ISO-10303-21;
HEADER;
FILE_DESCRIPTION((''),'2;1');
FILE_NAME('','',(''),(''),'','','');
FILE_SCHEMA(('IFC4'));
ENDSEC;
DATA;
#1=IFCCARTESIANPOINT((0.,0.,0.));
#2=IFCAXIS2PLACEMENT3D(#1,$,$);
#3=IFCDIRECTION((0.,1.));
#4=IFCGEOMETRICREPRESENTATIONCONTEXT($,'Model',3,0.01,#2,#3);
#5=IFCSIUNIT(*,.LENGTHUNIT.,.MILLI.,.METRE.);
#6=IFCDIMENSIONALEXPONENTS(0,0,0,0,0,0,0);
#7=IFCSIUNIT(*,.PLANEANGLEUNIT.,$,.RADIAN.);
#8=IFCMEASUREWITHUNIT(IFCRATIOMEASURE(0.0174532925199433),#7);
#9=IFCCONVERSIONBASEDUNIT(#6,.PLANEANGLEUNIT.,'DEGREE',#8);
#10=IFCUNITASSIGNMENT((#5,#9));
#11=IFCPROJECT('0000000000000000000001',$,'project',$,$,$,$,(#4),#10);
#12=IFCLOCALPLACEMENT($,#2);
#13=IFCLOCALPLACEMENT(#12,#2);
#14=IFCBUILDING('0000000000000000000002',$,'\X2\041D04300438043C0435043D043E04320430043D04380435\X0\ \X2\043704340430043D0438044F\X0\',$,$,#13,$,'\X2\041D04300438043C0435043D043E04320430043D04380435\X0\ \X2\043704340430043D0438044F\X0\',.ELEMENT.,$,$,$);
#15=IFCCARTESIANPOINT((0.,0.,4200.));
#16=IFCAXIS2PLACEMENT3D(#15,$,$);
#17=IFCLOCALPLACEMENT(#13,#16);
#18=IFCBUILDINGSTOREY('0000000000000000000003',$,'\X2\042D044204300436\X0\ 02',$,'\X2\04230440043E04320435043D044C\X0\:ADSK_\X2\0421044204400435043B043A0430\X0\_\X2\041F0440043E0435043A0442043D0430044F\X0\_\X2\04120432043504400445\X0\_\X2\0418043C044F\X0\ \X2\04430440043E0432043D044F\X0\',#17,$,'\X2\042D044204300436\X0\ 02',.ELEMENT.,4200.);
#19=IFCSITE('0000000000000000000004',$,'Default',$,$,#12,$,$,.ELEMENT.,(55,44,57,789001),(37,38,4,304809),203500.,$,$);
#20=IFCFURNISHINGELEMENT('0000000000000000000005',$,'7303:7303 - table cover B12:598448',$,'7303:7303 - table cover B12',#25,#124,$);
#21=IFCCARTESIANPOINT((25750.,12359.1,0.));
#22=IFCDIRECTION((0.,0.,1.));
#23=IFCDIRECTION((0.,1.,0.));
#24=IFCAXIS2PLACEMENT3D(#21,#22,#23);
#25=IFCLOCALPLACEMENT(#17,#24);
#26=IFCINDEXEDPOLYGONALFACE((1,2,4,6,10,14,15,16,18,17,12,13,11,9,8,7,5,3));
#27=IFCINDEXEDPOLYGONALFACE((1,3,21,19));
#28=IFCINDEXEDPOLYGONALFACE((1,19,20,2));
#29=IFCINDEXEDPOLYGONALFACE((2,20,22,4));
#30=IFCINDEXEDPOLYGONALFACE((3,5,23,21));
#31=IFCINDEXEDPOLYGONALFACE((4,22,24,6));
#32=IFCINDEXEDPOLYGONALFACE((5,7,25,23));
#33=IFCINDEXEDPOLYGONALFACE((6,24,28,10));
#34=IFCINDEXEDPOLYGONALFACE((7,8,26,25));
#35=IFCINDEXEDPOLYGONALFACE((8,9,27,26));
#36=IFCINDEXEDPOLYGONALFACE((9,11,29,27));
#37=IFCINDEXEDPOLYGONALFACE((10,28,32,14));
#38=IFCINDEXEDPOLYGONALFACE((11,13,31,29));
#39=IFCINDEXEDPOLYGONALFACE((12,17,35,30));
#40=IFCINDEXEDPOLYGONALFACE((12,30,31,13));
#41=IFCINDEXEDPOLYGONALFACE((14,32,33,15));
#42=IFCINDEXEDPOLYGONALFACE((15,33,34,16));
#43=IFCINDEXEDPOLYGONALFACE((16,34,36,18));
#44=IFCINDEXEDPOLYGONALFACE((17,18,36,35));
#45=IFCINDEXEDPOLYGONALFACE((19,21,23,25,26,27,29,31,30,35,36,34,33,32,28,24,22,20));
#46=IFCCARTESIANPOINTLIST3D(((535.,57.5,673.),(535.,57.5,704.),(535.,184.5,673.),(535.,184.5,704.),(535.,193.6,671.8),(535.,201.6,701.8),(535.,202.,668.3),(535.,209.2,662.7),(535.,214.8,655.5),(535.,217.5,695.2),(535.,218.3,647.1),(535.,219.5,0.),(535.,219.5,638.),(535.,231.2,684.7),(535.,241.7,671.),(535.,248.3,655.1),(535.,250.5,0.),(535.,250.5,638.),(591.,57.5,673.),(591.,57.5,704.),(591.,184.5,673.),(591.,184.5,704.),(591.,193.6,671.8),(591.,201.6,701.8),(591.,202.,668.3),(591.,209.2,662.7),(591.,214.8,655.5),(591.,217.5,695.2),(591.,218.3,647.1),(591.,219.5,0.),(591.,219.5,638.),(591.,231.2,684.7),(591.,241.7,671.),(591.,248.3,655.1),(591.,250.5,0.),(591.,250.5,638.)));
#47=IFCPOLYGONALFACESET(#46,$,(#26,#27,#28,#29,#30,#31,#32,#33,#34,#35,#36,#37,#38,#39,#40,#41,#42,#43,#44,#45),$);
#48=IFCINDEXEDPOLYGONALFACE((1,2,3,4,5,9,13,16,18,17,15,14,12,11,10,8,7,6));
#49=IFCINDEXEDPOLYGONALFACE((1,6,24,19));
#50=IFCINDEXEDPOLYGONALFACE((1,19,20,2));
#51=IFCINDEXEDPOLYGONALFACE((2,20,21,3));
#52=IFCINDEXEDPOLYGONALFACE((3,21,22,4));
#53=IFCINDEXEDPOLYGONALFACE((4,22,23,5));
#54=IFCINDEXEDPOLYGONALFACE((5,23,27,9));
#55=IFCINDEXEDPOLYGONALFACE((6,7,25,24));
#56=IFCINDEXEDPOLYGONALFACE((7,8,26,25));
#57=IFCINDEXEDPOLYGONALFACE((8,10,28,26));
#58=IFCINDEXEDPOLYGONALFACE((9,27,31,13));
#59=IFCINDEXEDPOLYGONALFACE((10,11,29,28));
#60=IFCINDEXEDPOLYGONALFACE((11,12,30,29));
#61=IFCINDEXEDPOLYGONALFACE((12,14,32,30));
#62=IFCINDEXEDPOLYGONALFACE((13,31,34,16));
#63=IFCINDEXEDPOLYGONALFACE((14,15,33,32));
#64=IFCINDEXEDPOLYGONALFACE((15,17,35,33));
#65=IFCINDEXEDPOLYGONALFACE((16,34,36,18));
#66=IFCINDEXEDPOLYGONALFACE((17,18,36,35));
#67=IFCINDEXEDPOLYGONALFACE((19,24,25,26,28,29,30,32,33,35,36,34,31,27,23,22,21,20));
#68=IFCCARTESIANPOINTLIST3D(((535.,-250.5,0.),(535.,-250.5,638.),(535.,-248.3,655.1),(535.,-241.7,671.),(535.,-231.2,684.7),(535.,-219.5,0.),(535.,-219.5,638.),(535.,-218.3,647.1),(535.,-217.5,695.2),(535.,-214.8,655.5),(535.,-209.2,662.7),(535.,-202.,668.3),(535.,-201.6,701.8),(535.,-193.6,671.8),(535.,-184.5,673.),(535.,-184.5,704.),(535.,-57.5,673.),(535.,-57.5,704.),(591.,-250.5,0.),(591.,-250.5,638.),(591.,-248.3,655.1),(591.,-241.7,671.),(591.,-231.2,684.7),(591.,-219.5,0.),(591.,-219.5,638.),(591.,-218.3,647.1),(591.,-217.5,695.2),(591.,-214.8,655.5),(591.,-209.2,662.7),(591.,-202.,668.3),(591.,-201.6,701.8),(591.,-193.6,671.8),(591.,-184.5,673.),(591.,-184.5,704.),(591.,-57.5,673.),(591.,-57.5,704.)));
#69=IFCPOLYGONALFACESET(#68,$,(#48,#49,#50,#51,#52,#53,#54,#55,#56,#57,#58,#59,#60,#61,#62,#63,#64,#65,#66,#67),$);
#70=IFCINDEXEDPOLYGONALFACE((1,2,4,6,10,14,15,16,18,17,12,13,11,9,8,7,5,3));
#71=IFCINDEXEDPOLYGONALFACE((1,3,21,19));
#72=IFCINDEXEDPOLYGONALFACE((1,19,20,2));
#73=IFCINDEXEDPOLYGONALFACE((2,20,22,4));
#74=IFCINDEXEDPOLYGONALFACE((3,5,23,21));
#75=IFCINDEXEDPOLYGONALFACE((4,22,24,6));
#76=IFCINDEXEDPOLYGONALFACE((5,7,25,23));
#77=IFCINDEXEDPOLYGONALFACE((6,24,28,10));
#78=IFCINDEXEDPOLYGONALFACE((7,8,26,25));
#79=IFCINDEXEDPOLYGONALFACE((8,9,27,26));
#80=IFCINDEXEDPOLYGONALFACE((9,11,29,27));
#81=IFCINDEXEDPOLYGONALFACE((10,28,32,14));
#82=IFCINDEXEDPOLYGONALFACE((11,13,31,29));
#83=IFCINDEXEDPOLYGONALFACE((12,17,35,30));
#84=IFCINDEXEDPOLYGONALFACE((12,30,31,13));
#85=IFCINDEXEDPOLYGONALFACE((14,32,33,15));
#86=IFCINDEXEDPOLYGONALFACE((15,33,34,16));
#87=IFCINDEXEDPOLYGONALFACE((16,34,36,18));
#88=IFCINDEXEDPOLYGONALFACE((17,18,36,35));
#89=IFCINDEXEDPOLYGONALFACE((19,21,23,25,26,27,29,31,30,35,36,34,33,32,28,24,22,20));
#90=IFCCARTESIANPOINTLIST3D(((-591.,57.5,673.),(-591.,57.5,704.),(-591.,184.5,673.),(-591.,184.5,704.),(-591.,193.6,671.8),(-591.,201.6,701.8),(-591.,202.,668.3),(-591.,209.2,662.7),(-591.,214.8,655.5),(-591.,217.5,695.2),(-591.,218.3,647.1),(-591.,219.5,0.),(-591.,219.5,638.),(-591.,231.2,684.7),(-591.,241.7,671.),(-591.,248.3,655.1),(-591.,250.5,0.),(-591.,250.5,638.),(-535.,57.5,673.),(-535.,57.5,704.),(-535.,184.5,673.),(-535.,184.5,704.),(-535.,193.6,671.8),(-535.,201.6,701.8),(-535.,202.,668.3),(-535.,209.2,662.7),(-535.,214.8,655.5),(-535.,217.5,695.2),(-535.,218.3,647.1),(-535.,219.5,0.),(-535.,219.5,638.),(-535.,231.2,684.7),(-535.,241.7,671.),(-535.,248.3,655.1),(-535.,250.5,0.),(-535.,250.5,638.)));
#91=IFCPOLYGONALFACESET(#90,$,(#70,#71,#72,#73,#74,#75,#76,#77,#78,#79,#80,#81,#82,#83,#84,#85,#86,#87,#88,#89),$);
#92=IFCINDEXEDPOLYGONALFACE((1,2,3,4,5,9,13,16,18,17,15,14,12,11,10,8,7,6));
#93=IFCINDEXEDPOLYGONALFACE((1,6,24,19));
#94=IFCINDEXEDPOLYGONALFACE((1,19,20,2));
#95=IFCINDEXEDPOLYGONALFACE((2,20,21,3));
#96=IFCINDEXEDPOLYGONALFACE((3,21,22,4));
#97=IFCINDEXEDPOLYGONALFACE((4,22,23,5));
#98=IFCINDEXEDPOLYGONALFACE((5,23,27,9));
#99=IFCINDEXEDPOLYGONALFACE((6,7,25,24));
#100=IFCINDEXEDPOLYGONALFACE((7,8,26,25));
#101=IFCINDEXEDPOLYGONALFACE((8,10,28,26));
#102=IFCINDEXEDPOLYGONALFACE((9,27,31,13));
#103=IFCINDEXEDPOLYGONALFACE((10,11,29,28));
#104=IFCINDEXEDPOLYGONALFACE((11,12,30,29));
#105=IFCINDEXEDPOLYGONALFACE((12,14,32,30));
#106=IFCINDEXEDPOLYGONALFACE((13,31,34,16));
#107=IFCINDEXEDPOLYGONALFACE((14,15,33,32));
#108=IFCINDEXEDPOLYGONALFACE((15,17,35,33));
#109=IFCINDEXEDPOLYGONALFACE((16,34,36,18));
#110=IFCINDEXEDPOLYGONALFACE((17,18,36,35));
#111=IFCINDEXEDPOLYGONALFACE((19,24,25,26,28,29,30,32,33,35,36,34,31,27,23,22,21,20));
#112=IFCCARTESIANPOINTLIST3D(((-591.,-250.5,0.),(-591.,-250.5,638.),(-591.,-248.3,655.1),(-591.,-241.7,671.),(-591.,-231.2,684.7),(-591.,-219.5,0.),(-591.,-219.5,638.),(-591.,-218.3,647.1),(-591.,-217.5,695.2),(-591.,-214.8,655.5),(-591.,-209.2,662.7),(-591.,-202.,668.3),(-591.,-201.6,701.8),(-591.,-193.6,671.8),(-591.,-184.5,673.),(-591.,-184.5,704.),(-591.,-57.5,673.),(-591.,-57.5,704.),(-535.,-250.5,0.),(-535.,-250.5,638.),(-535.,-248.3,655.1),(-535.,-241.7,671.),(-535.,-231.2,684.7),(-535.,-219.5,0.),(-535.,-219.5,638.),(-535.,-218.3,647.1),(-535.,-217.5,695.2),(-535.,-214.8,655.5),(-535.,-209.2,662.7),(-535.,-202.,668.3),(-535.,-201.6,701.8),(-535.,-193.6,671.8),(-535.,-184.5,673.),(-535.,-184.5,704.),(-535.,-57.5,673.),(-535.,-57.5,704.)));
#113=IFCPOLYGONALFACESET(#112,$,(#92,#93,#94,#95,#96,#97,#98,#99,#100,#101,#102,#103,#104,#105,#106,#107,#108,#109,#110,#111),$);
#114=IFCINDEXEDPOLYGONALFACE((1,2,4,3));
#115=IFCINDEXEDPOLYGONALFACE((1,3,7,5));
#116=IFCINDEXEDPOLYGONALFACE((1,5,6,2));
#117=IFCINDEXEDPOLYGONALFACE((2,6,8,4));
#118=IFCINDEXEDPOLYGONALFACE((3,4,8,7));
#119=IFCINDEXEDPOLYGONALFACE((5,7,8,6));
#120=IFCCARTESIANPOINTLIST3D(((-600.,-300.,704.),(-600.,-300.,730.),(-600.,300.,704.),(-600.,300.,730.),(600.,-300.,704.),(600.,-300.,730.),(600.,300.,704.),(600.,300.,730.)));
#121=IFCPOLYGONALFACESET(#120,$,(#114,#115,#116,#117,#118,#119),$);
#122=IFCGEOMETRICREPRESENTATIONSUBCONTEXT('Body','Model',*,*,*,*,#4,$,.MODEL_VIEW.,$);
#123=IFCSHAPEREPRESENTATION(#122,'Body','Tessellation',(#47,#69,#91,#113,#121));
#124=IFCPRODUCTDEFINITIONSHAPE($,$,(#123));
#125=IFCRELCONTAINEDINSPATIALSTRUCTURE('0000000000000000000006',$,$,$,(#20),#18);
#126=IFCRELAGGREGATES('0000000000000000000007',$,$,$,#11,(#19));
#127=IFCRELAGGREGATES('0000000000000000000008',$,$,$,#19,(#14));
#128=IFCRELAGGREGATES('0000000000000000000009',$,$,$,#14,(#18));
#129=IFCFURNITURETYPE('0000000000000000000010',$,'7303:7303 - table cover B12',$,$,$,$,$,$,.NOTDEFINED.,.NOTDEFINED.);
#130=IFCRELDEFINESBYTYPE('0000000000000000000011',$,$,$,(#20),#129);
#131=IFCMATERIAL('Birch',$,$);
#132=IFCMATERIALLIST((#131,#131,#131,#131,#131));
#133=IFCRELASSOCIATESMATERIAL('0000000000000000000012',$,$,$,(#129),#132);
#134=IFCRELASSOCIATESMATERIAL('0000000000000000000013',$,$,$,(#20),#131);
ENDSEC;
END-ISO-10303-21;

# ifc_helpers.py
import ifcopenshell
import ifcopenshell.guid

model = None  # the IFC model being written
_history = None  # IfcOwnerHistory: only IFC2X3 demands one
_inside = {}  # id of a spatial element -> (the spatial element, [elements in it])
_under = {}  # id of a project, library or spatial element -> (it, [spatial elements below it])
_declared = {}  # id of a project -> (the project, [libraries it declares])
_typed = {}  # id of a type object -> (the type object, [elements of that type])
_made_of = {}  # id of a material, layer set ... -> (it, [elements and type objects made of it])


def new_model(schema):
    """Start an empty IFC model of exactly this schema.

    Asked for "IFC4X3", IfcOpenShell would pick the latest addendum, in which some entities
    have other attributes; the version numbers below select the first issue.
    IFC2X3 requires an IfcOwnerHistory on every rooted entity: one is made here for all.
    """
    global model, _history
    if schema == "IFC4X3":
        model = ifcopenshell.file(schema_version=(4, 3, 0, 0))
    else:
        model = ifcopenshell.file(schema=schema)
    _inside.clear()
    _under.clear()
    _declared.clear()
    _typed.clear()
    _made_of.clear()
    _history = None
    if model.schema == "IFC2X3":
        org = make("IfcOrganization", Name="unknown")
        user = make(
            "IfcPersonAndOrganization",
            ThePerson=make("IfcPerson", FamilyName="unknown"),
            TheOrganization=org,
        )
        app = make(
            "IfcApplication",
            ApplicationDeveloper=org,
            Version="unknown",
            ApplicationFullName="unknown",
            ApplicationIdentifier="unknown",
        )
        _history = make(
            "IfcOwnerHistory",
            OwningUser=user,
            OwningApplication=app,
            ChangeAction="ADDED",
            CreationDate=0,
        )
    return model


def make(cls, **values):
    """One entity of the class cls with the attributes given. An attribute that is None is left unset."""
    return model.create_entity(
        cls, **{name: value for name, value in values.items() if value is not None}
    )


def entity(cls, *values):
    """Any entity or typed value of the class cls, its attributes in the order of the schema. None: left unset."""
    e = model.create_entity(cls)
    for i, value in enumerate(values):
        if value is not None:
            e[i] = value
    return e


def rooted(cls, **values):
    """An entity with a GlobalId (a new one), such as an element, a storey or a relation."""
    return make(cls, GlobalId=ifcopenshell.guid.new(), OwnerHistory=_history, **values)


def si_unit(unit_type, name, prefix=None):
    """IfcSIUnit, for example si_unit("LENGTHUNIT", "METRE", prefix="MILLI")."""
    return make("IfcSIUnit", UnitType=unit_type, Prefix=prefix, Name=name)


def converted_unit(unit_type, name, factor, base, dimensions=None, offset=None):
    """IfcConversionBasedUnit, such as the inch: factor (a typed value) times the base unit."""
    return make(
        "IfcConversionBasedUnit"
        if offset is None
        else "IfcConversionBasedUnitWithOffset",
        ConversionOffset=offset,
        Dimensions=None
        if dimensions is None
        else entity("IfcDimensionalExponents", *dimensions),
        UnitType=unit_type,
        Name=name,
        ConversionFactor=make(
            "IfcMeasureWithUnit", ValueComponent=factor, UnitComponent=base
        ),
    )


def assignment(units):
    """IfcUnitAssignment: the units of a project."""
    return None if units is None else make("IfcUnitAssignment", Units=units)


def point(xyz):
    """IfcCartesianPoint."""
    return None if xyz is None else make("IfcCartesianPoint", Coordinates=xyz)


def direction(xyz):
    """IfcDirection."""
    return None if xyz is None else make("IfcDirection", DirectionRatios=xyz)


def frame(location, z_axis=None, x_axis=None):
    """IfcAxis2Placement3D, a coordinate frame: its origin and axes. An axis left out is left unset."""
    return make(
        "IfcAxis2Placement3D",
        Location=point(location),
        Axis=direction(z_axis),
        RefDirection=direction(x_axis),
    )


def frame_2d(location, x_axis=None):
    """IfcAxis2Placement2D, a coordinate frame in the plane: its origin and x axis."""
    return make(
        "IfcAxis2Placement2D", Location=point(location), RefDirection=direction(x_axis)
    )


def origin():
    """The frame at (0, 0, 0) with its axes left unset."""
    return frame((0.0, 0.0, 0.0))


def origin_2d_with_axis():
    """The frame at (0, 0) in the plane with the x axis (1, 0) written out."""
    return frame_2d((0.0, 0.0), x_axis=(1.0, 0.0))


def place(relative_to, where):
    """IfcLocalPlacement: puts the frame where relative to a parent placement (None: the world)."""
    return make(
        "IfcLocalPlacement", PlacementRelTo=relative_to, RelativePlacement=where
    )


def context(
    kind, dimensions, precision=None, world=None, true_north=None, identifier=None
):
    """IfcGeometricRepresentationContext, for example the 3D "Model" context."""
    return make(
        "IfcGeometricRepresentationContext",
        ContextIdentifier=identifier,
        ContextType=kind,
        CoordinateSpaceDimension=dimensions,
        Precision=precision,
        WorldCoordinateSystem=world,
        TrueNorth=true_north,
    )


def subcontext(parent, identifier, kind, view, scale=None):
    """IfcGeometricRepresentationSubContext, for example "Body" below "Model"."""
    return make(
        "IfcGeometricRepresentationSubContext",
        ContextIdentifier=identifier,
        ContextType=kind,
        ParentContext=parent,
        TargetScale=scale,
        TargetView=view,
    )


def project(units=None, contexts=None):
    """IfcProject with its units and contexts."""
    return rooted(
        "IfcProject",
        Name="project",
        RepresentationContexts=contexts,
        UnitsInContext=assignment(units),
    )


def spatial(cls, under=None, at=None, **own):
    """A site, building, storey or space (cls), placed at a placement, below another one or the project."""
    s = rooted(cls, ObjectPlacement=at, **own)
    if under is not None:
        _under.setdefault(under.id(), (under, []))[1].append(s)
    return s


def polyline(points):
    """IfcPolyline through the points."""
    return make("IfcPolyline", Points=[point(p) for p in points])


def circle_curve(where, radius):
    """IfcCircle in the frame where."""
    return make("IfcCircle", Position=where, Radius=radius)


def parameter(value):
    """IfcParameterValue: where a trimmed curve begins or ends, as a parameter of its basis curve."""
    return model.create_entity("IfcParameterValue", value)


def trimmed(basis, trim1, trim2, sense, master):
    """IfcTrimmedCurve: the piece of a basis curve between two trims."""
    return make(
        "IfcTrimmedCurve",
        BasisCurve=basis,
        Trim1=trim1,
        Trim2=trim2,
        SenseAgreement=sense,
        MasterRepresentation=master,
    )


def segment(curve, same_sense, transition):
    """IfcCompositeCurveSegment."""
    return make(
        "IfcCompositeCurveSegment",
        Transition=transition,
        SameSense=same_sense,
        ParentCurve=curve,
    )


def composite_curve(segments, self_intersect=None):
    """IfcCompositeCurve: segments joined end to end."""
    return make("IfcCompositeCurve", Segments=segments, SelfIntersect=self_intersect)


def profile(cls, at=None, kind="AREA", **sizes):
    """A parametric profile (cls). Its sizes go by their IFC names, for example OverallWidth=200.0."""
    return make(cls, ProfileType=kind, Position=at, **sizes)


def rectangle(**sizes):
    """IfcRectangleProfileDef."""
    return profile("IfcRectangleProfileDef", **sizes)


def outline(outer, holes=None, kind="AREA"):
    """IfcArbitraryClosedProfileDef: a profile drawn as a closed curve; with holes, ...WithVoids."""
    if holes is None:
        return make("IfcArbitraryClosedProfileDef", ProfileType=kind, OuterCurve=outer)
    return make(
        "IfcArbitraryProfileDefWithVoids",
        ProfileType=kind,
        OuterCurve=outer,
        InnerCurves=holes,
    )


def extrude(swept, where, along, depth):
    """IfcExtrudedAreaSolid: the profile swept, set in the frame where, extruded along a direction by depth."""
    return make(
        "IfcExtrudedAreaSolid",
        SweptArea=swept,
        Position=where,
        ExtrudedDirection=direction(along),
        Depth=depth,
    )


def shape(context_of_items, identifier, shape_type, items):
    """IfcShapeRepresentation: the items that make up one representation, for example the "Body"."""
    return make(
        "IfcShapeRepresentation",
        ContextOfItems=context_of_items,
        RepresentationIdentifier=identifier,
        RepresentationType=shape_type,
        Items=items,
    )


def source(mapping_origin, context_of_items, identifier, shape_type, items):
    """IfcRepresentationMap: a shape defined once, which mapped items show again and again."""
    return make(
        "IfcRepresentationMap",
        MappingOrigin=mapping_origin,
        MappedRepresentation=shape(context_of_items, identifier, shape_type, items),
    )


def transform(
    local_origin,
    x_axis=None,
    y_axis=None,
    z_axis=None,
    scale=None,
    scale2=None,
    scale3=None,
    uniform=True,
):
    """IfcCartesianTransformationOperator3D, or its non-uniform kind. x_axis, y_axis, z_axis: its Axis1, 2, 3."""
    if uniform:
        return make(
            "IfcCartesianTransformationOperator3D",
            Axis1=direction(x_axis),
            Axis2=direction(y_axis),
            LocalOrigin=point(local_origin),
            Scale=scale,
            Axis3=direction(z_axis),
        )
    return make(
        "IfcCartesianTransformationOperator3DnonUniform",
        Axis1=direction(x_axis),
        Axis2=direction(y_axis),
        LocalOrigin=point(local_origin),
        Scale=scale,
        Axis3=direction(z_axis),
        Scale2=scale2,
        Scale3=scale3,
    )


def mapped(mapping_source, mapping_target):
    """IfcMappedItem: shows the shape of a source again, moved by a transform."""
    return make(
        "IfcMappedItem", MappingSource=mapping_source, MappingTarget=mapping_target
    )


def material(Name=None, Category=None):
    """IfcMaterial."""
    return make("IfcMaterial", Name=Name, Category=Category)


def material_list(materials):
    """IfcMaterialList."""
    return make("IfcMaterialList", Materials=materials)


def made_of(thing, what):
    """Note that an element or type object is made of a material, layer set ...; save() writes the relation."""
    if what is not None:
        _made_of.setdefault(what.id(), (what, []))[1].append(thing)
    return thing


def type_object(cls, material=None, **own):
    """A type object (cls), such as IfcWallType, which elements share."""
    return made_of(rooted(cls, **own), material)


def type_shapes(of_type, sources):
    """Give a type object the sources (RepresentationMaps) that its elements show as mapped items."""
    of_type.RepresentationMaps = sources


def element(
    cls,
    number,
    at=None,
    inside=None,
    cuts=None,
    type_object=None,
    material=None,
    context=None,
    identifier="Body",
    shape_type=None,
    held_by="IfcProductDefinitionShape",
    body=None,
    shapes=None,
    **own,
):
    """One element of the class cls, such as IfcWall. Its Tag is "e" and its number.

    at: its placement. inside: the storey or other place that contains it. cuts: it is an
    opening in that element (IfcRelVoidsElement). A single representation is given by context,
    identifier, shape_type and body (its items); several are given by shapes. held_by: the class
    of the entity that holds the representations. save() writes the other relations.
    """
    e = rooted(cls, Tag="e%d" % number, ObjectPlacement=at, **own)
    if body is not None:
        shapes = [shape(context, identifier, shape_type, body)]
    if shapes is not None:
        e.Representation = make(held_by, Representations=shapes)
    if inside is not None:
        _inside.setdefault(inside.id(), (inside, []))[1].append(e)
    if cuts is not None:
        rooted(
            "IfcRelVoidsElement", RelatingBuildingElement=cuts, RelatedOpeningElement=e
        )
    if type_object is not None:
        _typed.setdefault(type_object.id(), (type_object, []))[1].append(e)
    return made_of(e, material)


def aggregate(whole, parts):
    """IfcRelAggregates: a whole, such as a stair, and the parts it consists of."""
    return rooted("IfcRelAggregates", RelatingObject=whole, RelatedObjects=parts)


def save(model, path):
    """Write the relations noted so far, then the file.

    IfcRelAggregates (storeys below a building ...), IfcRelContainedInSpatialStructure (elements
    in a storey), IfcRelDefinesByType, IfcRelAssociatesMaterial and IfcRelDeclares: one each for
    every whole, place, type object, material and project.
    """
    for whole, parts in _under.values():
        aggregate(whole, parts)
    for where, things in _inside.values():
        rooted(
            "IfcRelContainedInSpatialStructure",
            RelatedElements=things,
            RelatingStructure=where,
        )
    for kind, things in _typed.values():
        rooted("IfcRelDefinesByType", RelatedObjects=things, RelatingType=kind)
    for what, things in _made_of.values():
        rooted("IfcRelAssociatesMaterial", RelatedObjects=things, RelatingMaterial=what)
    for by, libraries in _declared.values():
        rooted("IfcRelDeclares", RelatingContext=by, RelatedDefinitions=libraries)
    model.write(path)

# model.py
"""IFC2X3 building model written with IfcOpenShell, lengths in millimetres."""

from ifc_helpers import new_model, entity, si_unit, converted_unit, direction, frame, frame_2d, origin, origin_2d_with_axis, place, context, subcontext, project, spatial, polyline, circle_curve, parameter, trimmed, segment, composite_curve, rectangle, outline, extrude, source, transform, mapped, material, material_list, type_object, type_shapes, element, save


model = new_model("IFC2X3")

# Units and contexts
model_context = context("Model", 3, precision=0.01, world=origin(), true_north=direction((0.0, 1.0)))
body_context = subcontext(model_context, "Body", "Model", "MODEL_VIEW")
ifc_project = project(units=[si_unit("LENGTHUNIT", "METRE", prefix="MILLI"), converted_unit("PLANEANGLEUNIT", "DEGREE", entity("IfcRatioMeasure", 0.0174532925199433), si_unit("PLANEANGLEUNIT", "RADIAN"), dimensions=[0, 0, 0, 0, 0, 0, 0])], contexts=[model_context])

# Site, building, storey
site_placement = place(None, origin())
site = spatial("IfcSite", under=ifc_project, at=site_placement, Name="Default", CompositionType="ELEMENT", RefLatitude=(55, 44, 57, 789001), RefLongitude=(37, 38, 4, 304809), RefElevation=203500.0)
building_placement = place(site_placement, origin())
building = spatial("IfcBuilding", under=site, at=building_placement, Name="Наименование здания", LongName="Наименование здания", CompositionType="ELEMENT")
storey_placement = place(building_placement, frame((0.0, 0.0, 4200.0)))
storey = spatial("IfcBuildingStorey", under=building, at=storey_placement, Name="Этаж 02", ObjectType="Уровень:ADSK_Стрелка_Проектная_Вверх_Имя уровня", LongName="Этаж 02", CompositionType="ELEMENT", Elevation=4200.0)

# Furnishing element
ifc_material_1 = material(Name="Birch")
ifc_material_list_1 = material_list([ifc_material_1, ifc_material_1, ifc_material_1, ifc_material_1, ifc_material_1])
furniture_type_1 = type_object("IfcFurnitureType", Name="7303:7303 - table cover B12", material=ifc_material_list_1)
shared_shape_1 = source(origin(), body_context, "Body", "SweptSolid", [
    extrude(outline(composite_curve([segment(polyline([(-200.2, -120.5), (-169.2, -120.5)]), True, "CONTINUOUS"), segment(polyline([(-169.2, -120.5), (-169.2, 6.5)]), True, "CONTINUOUS"), segment(trimmed(circle_curve(frame_2d((-134.2, 6.5), x_axis=(0.0, -1.0)), 35.0), [parameter(180.0)], [parameter(270.0)], True, "PARAMETER"), False, "CONTINUOUS"), segment(polyline([(-134.2, 41.5), (503.8, 41.5)]), True, "CONTINUOUS"), segment(polyline([(503.8, 41.5), (503.8, 72.5)]), True, "CONTINUOUS"), segment(polyline([(503.8, 72.5), (-134.2, 72.5)]), True, "CONTINUOUS"), segment(trimmed(circle_curve(frame_2d((-134.2, 6.5), x_axis=(0.0, -1.0)), 66.0), [parameter(180.0)], [parameter(270.0)], True, "PARAMETER"), True, "CONTINUOUS"), segment(polyline([(-200.2, 6.5), (-200.2, -120.5)]), True, "CONTINUOUS")], self_intersect=False)), frame((535.0, 178.0, 503.8), z_axis=(1.0, 0.0, 0.0), x_axis=(0.0, 0.0, -1.0)), (0.0, 0.0, 1.0), 56.0),
    extrude(outline(composite_curve([segment(polyline([(-120.5, -200.2), (6.5, -200.2)]), True, "CONTINUOUS"), segment(trimmed(circle_curve(frame_2d((6.5, -134.2), x_axis=(-1.0, 0.0)), 66.0), [parameter(90.0)], [parameter(180.0)], True, "PARAMETER"), True, "CONTINUOUS"), segment(polyline([(72.5, -134.2), (72.5, 503.8)]), True, "CONTINUOUS"), segment(polyline([(72.5, 503.8), (41.5, 503.8)]), True, "CONTINUOUS"), segment(polyline([(41.5, 503.8), (41.5, -134.2)]), True, "CONTINUOUS"), segment(trimmed(circle_curve(frame_2d((6.5, -134.2), x_axis=(-1.0, 0.0)), 35.0), [parameter(90.0)], [parameter(180.0)], True, "PARAMETER"), False, "CONTINUOUS"), segment(polyline([(6.5, -169.2), (-120.5, -169.2)]), True, "CONTINUOUS"), segment(polyline([(-120.5, -169.2), (-120.5, -200.2)]), True, "CONTINUOUS")], self_intersect=False)), frame((535.0, -178.0, 503.8), z_axis=(1.0, 0.0, 0.0), x_axis=(0.0, -1.0, 0.0)), (0.0, 0.0, 1.0), 56.0),
    extrude(outline(composite_curve([segment(polyline([(-200.2, -120.5), (-169.2, -120.5)]), True, "CONTINUOUS"), segment(polyline([(-169.2, -120.5), (-169.2, 6.5)]), True, "CONTINUOUS"), segment(trimmed(circle_curve(frame_2d((-134.2, 6.5), x_axis=(0.0, -1.0)), 35.0), [parameter(180.0)], [parameter(270.0)], True, "PARAMETER"), False, "CONTINUOUS"), segment(polyline([(-134.2, 41.5), (503.8, 41.5)]), True, "CONTINUOUS"), segment(polyline([(503.8, 41.5), (503.8, 72.5)]), True, "CONTINUOUS"), segment(polyline([(503.8, 72.5), (-134.2, 72.5)]), True, "CONTINUOUS"), segment(trimmed(circle_curve(frame_2d((-134.2, 6.5), x_axis=(0.0, -1.0)), 66.0), [parameter(180.0)], [parameter(270.0)], True, "PARAMETER"), True, "CONTINUOUS"), segment(polyline([(-200.2, 6.5), (-200.2, -120.5)]), True, "CONTINUOUS")], self_intersect=False)), frame((-591.0, 178.0, 503.8), z_axis=(1.0, 0.0, 0.0), x_axis=(0.0, 0.0, -1.0)), (0.0, 0.0, 1.0), 56.0),
    extrude(outline(composite_curve([segment(polyline([(-120.5, -200.2), (6.5, -200.2)]), True, "CONTINUOUS"), segment(trimmed(circle_curve(frame_2d((6.5, -134.2), x_axis=(-1.0, 0.0)), 66.0), [parameter(90.0)], [parameter(180.0)], True, "PARAMETER"), True, "CONTINUOUS"), segment(polyline([(72.5, -134.2), (72.5, 503.8)]), True, "CONTINUOUS"), segment(polyline([(72.5, 503.8), (41.5, 503.8)]), True, "CONTINUOUS"), segment(polyline([(41.5, 503.8), (41.5, -134.2)]), True, "CONTINUOUS"), segment(trimmed(circle_curve(frame_2d((6.5, -134.2), x_axis=(-1.0, 0.0)), 35.0), [parameter(90.0)], [parameter(180.0)], True, "PARAMETER"), False, "CONTINUOUS"), segment(polyline([(6.5, -169.2), (-120.5, -169.2)]), True, "CONTINUOUS"), segment(polyline([(-120.5, -169.2), (-120.5, -200.2)]), True, "CONTINUOUS")], self_intersect=False)), frame((-591.0, -178.0, 503.8), z_axis=(1.0, 0.0, 0.0), x_axis=(0.0, -1.0, 0.0)), (0.0, 0.0, 1.0), 56.0),
    extrude(rectangle(XDim=1200.0, YDim=600.0, at=origin_2d_with_axis()), frame((0.0, 0.0, 704.0), z_axis=(0.0, 0.0, 1.0), x_axis=(-1.0, 0.0, 0.0)), (0.0, 0.0, 1.0), 26.0),
])
type_shapes(furniture_type_1, [shared_shape_1])
for number, where, z_axis, x_axis, name in (
    (1, (25750.0, 12359.1, 0.0), (0.0, 0.0, 1.0), (0.0, 1.0, 0.0), "7303:7303 - table cover B12:598448"),
):
    element("IfcFurnishingElement", number, at=place(storey_placement, frame(where, z_axis=z_axis, x_axis=x_axis)), inside=storey, type_object=furniture_type_1, material=ifc_material_1, Name=name, ObjectType="7303:7303 - table cover B12", context=body_context, shape_type="MappedRepresentation", body=[
        mapped(shared_shape_1, transform((0.0, 0.0, 0.0), scale=1.0)),
    ])

save(model, "model.ifc")
